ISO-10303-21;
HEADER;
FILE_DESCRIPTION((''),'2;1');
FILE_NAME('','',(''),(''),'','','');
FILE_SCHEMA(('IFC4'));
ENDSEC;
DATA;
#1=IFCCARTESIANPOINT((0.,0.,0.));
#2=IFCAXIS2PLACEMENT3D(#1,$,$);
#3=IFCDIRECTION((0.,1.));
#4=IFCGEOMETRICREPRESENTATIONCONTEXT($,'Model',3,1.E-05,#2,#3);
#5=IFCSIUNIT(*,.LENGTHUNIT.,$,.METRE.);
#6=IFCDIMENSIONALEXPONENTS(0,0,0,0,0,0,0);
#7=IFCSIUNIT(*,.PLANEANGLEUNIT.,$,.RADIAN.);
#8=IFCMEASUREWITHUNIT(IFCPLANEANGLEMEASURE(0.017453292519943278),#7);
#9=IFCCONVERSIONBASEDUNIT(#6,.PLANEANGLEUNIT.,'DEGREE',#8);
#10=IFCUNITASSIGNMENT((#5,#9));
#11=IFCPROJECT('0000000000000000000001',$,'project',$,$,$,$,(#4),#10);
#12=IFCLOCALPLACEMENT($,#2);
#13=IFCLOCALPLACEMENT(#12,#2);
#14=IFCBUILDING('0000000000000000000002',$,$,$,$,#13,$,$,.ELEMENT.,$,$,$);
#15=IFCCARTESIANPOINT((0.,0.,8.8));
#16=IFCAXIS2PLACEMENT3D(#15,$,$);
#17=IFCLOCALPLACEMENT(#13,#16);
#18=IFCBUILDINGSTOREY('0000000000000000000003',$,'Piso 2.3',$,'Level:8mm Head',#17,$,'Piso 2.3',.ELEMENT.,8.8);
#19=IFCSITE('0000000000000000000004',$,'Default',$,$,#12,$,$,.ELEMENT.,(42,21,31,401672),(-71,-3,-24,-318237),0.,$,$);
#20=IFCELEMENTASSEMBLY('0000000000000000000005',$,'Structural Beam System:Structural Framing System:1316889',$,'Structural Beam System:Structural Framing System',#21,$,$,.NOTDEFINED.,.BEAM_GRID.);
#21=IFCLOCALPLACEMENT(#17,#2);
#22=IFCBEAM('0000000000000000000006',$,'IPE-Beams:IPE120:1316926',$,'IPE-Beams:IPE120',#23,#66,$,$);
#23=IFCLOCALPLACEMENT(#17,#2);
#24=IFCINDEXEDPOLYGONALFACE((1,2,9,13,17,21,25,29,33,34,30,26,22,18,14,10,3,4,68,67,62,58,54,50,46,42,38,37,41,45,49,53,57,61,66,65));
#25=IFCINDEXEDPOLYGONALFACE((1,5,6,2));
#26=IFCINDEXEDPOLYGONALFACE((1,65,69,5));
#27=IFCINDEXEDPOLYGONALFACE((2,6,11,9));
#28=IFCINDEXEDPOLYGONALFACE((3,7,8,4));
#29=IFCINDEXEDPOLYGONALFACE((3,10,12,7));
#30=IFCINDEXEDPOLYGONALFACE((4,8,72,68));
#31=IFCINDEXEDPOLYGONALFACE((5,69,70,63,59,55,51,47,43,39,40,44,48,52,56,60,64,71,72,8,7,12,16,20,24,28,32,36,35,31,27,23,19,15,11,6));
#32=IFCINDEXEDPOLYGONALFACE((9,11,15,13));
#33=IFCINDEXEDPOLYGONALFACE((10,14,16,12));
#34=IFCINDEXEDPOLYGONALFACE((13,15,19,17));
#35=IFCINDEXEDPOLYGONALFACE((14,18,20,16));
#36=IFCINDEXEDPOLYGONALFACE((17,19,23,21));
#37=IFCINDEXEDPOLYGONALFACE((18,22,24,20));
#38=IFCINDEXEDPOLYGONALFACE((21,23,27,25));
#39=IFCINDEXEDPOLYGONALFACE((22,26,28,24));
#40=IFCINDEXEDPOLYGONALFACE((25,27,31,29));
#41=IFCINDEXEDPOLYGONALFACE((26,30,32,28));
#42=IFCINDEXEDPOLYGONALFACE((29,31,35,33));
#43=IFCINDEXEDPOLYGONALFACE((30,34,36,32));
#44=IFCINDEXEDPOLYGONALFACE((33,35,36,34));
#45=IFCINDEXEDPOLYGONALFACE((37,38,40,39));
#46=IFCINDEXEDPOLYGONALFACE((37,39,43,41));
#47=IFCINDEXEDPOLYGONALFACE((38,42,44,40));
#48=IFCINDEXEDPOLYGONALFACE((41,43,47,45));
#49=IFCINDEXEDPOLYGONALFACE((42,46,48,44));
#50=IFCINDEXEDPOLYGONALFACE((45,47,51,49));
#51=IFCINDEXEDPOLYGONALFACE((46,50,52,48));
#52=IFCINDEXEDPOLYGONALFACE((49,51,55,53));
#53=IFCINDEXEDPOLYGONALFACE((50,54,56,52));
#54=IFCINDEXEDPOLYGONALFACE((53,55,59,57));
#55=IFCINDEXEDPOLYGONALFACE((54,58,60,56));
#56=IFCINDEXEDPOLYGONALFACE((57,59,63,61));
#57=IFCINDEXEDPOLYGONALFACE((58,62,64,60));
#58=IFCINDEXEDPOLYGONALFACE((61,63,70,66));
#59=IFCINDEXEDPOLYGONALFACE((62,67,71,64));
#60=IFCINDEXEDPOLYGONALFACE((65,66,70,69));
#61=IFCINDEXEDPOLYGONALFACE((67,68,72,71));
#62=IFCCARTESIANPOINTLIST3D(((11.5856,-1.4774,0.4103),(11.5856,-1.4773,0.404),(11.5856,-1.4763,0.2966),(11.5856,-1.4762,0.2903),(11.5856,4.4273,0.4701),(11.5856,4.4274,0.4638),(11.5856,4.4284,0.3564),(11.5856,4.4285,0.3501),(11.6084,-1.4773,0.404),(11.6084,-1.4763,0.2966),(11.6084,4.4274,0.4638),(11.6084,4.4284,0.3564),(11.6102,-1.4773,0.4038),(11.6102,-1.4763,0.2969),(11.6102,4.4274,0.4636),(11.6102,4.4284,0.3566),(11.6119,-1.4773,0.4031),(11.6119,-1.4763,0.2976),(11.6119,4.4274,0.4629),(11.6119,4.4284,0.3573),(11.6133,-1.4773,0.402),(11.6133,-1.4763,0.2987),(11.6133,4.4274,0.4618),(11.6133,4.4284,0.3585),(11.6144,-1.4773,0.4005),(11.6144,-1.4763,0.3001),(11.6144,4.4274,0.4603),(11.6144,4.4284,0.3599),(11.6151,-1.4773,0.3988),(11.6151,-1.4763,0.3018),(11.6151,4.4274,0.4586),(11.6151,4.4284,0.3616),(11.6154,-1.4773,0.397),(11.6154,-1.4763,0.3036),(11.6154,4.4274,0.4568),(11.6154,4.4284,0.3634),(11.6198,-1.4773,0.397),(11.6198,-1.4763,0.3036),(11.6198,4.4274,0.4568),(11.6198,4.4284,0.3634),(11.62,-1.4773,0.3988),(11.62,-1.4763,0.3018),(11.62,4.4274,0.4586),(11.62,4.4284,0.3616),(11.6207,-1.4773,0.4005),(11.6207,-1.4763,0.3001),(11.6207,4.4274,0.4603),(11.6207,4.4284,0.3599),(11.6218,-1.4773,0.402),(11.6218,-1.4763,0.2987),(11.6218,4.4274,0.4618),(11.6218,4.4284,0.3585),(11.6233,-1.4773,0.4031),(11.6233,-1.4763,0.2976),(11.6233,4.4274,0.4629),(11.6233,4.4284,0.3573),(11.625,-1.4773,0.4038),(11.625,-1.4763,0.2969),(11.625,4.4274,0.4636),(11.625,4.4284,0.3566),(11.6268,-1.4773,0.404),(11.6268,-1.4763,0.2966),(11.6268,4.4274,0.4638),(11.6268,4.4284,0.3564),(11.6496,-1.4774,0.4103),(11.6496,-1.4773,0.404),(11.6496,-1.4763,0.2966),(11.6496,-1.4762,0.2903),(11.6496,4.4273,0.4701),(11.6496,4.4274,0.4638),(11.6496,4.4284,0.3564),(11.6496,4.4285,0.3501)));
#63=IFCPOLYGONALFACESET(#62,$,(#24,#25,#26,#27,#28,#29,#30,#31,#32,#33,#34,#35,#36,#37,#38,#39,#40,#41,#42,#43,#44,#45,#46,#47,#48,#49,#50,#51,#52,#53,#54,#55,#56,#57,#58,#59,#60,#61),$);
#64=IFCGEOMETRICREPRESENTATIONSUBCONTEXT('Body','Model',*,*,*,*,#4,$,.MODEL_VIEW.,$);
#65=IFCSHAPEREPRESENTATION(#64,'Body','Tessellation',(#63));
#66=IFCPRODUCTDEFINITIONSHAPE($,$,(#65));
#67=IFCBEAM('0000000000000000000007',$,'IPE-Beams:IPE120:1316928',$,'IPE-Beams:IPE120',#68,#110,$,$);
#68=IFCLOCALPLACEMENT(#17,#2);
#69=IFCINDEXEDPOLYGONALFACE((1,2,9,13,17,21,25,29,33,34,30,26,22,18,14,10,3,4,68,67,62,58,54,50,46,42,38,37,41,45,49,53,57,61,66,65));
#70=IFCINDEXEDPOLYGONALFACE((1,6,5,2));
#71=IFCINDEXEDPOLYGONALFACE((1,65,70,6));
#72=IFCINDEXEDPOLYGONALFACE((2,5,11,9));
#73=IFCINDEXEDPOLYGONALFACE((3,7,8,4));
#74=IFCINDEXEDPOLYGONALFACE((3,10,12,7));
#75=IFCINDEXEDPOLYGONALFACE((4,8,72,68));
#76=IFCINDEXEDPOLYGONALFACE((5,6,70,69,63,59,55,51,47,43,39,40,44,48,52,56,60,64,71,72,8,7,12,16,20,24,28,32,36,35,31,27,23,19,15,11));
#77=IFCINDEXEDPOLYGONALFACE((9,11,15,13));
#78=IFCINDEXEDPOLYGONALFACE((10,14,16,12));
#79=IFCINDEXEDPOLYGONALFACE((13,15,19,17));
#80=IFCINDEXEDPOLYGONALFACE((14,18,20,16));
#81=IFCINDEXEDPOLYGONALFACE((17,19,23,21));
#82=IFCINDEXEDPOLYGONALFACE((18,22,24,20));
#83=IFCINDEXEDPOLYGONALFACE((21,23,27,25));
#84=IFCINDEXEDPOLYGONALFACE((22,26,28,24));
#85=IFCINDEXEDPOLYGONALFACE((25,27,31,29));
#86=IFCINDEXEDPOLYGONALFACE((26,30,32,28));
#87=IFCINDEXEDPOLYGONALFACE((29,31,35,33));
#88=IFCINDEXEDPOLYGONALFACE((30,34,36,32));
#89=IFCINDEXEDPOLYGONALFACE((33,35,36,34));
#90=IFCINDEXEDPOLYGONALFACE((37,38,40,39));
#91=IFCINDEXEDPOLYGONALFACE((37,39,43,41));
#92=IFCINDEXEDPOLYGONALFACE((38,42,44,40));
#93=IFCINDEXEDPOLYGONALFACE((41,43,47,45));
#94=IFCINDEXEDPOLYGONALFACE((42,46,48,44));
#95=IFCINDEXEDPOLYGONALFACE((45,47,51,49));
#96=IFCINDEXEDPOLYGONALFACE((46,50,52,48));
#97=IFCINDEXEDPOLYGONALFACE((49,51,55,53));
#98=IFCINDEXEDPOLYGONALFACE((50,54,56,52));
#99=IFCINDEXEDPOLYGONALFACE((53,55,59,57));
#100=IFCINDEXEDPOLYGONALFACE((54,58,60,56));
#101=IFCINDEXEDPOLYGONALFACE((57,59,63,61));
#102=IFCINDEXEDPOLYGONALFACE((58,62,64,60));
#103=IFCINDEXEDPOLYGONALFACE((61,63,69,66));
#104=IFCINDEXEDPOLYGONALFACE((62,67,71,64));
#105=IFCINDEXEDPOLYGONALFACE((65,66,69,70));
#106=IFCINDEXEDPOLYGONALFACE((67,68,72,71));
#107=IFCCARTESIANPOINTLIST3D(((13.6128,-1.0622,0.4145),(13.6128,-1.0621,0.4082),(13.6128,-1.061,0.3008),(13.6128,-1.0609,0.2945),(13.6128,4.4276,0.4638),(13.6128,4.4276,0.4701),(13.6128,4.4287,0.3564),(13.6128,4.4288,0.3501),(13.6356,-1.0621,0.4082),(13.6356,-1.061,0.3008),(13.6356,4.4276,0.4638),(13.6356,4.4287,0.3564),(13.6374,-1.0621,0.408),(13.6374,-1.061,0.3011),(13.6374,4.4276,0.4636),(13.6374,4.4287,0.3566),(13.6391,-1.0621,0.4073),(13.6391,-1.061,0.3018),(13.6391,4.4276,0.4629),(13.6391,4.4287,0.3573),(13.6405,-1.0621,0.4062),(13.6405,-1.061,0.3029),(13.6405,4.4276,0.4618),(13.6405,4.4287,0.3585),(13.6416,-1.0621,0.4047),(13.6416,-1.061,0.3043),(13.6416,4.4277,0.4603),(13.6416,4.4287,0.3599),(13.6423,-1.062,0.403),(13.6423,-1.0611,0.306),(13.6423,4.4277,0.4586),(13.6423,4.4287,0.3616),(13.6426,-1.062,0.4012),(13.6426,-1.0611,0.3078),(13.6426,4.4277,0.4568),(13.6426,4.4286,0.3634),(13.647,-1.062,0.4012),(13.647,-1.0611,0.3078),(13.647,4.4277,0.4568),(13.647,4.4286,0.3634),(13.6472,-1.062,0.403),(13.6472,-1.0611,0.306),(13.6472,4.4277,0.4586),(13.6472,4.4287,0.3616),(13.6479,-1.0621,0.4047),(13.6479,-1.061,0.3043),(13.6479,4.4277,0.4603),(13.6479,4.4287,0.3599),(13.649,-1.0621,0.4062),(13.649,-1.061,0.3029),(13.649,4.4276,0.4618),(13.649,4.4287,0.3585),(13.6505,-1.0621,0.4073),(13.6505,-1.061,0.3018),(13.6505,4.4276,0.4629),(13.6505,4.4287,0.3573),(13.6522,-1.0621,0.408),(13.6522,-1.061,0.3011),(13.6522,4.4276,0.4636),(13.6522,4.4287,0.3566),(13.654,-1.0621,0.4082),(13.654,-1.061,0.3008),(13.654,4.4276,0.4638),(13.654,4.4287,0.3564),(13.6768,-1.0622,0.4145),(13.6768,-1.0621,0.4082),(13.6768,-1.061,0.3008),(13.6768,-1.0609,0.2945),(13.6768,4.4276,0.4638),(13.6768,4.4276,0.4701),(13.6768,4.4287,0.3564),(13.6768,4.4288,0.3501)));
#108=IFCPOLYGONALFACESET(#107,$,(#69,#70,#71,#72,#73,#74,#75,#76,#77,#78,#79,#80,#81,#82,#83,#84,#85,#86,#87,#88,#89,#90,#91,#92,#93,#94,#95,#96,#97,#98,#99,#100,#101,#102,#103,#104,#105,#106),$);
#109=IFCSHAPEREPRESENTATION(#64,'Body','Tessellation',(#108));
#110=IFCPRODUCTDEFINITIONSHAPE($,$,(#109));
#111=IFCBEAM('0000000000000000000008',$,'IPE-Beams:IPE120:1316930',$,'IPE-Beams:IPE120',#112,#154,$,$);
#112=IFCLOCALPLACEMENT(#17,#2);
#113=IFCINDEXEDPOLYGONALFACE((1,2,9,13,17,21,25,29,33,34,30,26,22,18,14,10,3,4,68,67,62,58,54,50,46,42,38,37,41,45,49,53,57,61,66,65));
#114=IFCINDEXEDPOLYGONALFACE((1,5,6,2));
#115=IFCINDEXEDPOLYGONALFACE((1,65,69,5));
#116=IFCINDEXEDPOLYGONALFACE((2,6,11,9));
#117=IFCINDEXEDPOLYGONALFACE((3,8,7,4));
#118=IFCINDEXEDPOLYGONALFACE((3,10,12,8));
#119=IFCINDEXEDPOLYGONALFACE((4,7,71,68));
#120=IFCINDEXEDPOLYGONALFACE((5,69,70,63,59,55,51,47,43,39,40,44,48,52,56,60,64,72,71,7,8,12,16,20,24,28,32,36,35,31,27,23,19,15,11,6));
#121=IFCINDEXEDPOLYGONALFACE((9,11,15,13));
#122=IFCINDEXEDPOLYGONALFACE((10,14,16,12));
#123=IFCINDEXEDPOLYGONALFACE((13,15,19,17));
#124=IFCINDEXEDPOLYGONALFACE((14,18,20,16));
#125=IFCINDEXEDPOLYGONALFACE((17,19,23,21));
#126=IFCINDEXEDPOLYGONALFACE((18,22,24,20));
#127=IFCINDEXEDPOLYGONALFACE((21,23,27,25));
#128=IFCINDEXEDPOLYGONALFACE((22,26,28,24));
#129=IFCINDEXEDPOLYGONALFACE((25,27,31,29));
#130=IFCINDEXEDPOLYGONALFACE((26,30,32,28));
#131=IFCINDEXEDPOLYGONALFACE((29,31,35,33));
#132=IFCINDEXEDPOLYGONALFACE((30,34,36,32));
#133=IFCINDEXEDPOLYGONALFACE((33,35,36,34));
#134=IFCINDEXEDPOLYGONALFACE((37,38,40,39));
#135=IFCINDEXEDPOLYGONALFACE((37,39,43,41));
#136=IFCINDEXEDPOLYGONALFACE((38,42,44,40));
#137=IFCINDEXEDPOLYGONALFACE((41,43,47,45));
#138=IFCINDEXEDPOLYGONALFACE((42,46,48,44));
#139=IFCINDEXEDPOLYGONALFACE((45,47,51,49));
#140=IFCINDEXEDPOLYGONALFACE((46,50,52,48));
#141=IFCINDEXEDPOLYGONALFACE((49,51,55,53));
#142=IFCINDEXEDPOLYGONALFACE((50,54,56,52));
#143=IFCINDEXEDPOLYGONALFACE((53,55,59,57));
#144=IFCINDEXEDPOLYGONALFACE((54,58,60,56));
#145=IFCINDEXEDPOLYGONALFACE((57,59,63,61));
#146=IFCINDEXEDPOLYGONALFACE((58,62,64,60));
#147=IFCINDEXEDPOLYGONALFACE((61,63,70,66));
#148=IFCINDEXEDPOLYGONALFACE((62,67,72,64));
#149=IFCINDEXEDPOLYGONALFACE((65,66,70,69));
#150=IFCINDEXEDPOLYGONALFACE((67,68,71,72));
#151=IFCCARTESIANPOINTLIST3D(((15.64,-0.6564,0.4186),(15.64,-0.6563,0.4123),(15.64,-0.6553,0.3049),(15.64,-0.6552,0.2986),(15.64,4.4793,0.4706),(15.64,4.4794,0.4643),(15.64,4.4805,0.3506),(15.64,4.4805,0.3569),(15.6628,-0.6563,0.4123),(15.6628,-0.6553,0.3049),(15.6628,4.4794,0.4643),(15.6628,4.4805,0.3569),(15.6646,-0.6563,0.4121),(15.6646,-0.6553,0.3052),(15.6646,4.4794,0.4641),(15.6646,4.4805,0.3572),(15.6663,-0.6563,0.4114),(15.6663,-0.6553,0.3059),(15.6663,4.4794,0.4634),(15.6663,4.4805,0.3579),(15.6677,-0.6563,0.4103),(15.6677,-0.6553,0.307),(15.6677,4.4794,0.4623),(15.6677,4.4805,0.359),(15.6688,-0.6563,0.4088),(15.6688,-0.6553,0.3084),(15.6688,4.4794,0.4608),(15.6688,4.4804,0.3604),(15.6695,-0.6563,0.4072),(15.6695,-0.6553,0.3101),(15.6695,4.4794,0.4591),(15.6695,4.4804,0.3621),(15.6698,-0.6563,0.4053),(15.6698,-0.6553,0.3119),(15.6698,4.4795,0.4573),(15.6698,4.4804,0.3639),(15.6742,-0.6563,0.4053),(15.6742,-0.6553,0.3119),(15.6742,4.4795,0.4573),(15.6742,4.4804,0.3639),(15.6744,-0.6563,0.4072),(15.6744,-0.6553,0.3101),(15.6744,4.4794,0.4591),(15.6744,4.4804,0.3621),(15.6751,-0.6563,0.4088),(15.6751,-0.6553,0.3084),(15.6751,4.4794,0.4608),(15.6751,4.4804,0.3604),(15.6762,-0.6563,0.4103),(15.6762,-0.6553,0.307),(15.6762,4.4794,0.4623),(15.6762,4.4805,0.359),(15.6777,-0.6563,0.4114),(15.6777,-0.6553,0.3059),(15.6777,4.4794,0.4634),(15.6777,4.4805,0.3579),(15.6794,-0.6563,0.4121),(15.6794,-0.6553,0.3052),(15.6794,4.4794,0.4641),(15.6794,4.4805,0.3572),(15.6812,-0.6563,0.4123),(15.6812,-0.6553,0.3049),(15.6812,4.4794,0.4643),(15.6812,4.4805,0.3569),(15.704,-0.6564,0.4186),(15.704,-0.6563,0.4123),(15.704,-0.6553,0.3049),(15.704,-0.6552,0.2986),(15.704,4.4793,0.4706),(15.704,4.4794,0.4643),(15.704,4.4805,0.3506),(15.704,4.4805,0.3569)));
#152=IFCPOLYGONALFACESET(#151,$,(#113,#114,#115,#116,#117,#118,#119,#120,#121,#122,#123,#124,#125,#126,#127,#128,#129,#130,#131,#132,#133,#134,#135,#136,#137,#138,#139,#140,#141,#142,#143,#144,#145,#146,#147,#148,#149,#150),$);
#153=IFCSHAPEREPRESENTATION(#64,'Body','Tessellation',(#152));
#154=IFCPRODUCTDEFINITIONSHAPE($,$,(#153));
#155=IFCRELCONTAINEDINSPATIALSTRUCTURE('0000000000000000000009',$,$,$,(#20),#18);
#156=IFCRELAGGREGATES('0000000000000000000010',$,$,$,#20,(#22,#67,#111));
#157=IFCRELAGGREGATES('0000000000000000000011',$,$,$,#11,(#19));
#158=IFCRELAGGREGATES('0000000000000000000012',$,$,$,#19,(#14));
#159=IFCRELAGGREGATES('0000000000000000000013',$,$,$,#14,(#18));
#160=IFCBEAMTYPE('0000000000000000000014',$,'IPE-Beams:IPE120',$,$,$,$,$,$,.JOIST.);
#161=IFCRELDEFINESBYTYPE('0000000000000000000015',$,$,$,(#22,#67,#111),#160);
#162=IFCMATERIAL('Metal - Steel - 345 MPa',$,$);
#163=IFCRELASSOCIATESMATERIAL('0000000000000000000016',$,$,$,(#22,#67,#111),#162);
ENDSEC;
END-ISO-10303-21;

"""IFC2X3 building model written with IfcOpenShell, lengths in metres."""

from ifc_helpers import new_model, entity, si_unit, converted_unit, direction, frame, frame_2d, origin, place, context, subcontext, project, spatial, i_section, extrude, material, type_object, element, aggregate, save


model = new_model("IFC2X3")

# Units and contexts
model_context = context("Model", 3, precision=1e-05, world=origin(), true_north=direction((0.0, 1.0)))
body_context = subcontext(model_context, "Body", "Model", "MODEL_VIEW")
ifc_project = project(units=[si_unit("LENGTHUNIT", "METRE"), converted_unit("PLANEANGLEUNIT", "DEGREE", entity("IfcPlaneAngleMeasure", 0.017453292519943278), si_unit("PLANEANGLEUNIT", "RADIAN"), dimensions=[0, 0, 0, 0, 0, 0, 0])], contexts=[model_context])

# Site, building, storey
site_placement = place(None, origin())
site = spatial("IfcSite", under=ifc_project, at=site_placement, Name="Default", CompositionType="ELEMENT", RefLatitude=(42, 21, 31, 401672), RefLongitude=(-71, -3, -24, -318237), RefElevation=0.0)
building_placement = place(site_placement, origin())
building = spatial("IfcBuilding", under=site, at=building_placement, CompositionType="ELEMENT")
storey_placement = place(building_placement, frame((0.0, 0.0, 8.8)))
storey = spatial("IfcBuildingStorey", under=building, at=storey_placement, Name="Piso 2.3", ObjectType="Level:8mm Head", LongName="Piso 2.3", CompositionType="ELEMENT", Elevation=8.8)

# Shared definitions
ifc_material_1 = material(Name="Metal - Steel - 345 MPa")

# Element assembly, beams
assembly_placement = place(storey_placement, origin())
assembly = element("IfcElementAssembly", 1, at=assembly_placement, inside=storey, Name="Structural Beam System:Structural Framing System:1316889", ObjectType="Structural Beam System:Structural Framing System", AssemblyPlace="NOTDEFINED", PredefinedType="BEAM_GRID")
beam_type_1 = type_object("IfcBeamType", Name="IPE-Beams:IPE120", PredefinedType="JOIST")
beam_1_placement = place(assembly_placement, frame((11.6176, -1.5365, 0.4097), z_axis=(0.0, -0.010123, 0.999949), x_axis=(0.0, 0.999949, 0.010123)))
beam_1 = element("IfcBeam", 2, at=beam_1_placement, type_object=beam_type_1, material=ifc_material_1, Name="IPE-Beams:IPE120:1316926", ObjectType="IPE-Beams:IPE120", context=body_context, shape_type="SweptSolid", body=[
    extrude(i_section(OverallWidth=0.064, OverallDepth=0.12, WebThickness=0.0044, FlangeThickness=0.0063, FilletRadius=0.007, at=frame_2d((0.0, 0.0), x_axis=(0.0, 1.0))), frame((0.0591, 0.0, -0.06), z_axis=(1.0, 0.0, 0.0), x_axis=(0.0, 0.0, -1.0)), (0.0, 0.0, 1.0), 5.905),
])
beam_2_placement = place(assembly_placement, frame((13.6448, -1.122, 0.4139), z_axis=(0.0, -0.010123, 0.999949), x_axis=(0.0, 0.999949, 0.010123)))
beam_2 = element("IfcBeam", 3, at=beam_2_placement, type_object=beam_type_1, material=ifc_material_1, Name="IPE-Beams:IPE120:1316928", ObjectType="IPE-Beams:IPE120", context=body_context, shape_type="SweptSolid", body=[
    extrude(i_section(OverallWidth=0.064, OverallDepth=0.12, WebThickness=0.0044, FlangeThickness=0.0063, FilletRadius=0.007, at=frame_2d((0.0, 0.0), x_axis=(0.0, 1.0))), frame((0.0599, 0.0, -0.06), z_axis=(1.0, 0.0, 0.0), x_axis=(0.0, 0.0, -1.0)), (0.0, 0.0, 1.0), 5.49),
])
beam_3_placement = place(assembly_placement, frame((15.672, -0.7075, 0.4181), z_axis=(0.0, -0.010123, 0.999949), x_axis=(0.0, 0.999949, 0.010123)))
beam_3 = element("IfcBeam", 4, at=beam_3_placement, type_object=beam_type_1, material=ifc_material_1, Name="IPE-Beams:IPE120:1316930", ObjectType="IPE-Beams:IPE120", context=body_context, shape_type="SweptSolid", body=[
    extrude(i_section(OverallWidth=0.064, OverallDepth=0.12, WebThickness=0.0044, FlangeThickness=0.0063, FilletRadius=0.007, at=frame_2d((0.0, 0.0), x_axis=(0.0, 1.0))), frame((0.0511, 0.0, -0.06), z_axis=(1.0, 0.0, 0.0), x_axis=(0.0, 0.0, -1.0)), (0.0, 0.0, 1.0), 5.136),
])
aggregate(assembly, [beam_1, beam_2, beam_3])

save(model, "model.ifc")
